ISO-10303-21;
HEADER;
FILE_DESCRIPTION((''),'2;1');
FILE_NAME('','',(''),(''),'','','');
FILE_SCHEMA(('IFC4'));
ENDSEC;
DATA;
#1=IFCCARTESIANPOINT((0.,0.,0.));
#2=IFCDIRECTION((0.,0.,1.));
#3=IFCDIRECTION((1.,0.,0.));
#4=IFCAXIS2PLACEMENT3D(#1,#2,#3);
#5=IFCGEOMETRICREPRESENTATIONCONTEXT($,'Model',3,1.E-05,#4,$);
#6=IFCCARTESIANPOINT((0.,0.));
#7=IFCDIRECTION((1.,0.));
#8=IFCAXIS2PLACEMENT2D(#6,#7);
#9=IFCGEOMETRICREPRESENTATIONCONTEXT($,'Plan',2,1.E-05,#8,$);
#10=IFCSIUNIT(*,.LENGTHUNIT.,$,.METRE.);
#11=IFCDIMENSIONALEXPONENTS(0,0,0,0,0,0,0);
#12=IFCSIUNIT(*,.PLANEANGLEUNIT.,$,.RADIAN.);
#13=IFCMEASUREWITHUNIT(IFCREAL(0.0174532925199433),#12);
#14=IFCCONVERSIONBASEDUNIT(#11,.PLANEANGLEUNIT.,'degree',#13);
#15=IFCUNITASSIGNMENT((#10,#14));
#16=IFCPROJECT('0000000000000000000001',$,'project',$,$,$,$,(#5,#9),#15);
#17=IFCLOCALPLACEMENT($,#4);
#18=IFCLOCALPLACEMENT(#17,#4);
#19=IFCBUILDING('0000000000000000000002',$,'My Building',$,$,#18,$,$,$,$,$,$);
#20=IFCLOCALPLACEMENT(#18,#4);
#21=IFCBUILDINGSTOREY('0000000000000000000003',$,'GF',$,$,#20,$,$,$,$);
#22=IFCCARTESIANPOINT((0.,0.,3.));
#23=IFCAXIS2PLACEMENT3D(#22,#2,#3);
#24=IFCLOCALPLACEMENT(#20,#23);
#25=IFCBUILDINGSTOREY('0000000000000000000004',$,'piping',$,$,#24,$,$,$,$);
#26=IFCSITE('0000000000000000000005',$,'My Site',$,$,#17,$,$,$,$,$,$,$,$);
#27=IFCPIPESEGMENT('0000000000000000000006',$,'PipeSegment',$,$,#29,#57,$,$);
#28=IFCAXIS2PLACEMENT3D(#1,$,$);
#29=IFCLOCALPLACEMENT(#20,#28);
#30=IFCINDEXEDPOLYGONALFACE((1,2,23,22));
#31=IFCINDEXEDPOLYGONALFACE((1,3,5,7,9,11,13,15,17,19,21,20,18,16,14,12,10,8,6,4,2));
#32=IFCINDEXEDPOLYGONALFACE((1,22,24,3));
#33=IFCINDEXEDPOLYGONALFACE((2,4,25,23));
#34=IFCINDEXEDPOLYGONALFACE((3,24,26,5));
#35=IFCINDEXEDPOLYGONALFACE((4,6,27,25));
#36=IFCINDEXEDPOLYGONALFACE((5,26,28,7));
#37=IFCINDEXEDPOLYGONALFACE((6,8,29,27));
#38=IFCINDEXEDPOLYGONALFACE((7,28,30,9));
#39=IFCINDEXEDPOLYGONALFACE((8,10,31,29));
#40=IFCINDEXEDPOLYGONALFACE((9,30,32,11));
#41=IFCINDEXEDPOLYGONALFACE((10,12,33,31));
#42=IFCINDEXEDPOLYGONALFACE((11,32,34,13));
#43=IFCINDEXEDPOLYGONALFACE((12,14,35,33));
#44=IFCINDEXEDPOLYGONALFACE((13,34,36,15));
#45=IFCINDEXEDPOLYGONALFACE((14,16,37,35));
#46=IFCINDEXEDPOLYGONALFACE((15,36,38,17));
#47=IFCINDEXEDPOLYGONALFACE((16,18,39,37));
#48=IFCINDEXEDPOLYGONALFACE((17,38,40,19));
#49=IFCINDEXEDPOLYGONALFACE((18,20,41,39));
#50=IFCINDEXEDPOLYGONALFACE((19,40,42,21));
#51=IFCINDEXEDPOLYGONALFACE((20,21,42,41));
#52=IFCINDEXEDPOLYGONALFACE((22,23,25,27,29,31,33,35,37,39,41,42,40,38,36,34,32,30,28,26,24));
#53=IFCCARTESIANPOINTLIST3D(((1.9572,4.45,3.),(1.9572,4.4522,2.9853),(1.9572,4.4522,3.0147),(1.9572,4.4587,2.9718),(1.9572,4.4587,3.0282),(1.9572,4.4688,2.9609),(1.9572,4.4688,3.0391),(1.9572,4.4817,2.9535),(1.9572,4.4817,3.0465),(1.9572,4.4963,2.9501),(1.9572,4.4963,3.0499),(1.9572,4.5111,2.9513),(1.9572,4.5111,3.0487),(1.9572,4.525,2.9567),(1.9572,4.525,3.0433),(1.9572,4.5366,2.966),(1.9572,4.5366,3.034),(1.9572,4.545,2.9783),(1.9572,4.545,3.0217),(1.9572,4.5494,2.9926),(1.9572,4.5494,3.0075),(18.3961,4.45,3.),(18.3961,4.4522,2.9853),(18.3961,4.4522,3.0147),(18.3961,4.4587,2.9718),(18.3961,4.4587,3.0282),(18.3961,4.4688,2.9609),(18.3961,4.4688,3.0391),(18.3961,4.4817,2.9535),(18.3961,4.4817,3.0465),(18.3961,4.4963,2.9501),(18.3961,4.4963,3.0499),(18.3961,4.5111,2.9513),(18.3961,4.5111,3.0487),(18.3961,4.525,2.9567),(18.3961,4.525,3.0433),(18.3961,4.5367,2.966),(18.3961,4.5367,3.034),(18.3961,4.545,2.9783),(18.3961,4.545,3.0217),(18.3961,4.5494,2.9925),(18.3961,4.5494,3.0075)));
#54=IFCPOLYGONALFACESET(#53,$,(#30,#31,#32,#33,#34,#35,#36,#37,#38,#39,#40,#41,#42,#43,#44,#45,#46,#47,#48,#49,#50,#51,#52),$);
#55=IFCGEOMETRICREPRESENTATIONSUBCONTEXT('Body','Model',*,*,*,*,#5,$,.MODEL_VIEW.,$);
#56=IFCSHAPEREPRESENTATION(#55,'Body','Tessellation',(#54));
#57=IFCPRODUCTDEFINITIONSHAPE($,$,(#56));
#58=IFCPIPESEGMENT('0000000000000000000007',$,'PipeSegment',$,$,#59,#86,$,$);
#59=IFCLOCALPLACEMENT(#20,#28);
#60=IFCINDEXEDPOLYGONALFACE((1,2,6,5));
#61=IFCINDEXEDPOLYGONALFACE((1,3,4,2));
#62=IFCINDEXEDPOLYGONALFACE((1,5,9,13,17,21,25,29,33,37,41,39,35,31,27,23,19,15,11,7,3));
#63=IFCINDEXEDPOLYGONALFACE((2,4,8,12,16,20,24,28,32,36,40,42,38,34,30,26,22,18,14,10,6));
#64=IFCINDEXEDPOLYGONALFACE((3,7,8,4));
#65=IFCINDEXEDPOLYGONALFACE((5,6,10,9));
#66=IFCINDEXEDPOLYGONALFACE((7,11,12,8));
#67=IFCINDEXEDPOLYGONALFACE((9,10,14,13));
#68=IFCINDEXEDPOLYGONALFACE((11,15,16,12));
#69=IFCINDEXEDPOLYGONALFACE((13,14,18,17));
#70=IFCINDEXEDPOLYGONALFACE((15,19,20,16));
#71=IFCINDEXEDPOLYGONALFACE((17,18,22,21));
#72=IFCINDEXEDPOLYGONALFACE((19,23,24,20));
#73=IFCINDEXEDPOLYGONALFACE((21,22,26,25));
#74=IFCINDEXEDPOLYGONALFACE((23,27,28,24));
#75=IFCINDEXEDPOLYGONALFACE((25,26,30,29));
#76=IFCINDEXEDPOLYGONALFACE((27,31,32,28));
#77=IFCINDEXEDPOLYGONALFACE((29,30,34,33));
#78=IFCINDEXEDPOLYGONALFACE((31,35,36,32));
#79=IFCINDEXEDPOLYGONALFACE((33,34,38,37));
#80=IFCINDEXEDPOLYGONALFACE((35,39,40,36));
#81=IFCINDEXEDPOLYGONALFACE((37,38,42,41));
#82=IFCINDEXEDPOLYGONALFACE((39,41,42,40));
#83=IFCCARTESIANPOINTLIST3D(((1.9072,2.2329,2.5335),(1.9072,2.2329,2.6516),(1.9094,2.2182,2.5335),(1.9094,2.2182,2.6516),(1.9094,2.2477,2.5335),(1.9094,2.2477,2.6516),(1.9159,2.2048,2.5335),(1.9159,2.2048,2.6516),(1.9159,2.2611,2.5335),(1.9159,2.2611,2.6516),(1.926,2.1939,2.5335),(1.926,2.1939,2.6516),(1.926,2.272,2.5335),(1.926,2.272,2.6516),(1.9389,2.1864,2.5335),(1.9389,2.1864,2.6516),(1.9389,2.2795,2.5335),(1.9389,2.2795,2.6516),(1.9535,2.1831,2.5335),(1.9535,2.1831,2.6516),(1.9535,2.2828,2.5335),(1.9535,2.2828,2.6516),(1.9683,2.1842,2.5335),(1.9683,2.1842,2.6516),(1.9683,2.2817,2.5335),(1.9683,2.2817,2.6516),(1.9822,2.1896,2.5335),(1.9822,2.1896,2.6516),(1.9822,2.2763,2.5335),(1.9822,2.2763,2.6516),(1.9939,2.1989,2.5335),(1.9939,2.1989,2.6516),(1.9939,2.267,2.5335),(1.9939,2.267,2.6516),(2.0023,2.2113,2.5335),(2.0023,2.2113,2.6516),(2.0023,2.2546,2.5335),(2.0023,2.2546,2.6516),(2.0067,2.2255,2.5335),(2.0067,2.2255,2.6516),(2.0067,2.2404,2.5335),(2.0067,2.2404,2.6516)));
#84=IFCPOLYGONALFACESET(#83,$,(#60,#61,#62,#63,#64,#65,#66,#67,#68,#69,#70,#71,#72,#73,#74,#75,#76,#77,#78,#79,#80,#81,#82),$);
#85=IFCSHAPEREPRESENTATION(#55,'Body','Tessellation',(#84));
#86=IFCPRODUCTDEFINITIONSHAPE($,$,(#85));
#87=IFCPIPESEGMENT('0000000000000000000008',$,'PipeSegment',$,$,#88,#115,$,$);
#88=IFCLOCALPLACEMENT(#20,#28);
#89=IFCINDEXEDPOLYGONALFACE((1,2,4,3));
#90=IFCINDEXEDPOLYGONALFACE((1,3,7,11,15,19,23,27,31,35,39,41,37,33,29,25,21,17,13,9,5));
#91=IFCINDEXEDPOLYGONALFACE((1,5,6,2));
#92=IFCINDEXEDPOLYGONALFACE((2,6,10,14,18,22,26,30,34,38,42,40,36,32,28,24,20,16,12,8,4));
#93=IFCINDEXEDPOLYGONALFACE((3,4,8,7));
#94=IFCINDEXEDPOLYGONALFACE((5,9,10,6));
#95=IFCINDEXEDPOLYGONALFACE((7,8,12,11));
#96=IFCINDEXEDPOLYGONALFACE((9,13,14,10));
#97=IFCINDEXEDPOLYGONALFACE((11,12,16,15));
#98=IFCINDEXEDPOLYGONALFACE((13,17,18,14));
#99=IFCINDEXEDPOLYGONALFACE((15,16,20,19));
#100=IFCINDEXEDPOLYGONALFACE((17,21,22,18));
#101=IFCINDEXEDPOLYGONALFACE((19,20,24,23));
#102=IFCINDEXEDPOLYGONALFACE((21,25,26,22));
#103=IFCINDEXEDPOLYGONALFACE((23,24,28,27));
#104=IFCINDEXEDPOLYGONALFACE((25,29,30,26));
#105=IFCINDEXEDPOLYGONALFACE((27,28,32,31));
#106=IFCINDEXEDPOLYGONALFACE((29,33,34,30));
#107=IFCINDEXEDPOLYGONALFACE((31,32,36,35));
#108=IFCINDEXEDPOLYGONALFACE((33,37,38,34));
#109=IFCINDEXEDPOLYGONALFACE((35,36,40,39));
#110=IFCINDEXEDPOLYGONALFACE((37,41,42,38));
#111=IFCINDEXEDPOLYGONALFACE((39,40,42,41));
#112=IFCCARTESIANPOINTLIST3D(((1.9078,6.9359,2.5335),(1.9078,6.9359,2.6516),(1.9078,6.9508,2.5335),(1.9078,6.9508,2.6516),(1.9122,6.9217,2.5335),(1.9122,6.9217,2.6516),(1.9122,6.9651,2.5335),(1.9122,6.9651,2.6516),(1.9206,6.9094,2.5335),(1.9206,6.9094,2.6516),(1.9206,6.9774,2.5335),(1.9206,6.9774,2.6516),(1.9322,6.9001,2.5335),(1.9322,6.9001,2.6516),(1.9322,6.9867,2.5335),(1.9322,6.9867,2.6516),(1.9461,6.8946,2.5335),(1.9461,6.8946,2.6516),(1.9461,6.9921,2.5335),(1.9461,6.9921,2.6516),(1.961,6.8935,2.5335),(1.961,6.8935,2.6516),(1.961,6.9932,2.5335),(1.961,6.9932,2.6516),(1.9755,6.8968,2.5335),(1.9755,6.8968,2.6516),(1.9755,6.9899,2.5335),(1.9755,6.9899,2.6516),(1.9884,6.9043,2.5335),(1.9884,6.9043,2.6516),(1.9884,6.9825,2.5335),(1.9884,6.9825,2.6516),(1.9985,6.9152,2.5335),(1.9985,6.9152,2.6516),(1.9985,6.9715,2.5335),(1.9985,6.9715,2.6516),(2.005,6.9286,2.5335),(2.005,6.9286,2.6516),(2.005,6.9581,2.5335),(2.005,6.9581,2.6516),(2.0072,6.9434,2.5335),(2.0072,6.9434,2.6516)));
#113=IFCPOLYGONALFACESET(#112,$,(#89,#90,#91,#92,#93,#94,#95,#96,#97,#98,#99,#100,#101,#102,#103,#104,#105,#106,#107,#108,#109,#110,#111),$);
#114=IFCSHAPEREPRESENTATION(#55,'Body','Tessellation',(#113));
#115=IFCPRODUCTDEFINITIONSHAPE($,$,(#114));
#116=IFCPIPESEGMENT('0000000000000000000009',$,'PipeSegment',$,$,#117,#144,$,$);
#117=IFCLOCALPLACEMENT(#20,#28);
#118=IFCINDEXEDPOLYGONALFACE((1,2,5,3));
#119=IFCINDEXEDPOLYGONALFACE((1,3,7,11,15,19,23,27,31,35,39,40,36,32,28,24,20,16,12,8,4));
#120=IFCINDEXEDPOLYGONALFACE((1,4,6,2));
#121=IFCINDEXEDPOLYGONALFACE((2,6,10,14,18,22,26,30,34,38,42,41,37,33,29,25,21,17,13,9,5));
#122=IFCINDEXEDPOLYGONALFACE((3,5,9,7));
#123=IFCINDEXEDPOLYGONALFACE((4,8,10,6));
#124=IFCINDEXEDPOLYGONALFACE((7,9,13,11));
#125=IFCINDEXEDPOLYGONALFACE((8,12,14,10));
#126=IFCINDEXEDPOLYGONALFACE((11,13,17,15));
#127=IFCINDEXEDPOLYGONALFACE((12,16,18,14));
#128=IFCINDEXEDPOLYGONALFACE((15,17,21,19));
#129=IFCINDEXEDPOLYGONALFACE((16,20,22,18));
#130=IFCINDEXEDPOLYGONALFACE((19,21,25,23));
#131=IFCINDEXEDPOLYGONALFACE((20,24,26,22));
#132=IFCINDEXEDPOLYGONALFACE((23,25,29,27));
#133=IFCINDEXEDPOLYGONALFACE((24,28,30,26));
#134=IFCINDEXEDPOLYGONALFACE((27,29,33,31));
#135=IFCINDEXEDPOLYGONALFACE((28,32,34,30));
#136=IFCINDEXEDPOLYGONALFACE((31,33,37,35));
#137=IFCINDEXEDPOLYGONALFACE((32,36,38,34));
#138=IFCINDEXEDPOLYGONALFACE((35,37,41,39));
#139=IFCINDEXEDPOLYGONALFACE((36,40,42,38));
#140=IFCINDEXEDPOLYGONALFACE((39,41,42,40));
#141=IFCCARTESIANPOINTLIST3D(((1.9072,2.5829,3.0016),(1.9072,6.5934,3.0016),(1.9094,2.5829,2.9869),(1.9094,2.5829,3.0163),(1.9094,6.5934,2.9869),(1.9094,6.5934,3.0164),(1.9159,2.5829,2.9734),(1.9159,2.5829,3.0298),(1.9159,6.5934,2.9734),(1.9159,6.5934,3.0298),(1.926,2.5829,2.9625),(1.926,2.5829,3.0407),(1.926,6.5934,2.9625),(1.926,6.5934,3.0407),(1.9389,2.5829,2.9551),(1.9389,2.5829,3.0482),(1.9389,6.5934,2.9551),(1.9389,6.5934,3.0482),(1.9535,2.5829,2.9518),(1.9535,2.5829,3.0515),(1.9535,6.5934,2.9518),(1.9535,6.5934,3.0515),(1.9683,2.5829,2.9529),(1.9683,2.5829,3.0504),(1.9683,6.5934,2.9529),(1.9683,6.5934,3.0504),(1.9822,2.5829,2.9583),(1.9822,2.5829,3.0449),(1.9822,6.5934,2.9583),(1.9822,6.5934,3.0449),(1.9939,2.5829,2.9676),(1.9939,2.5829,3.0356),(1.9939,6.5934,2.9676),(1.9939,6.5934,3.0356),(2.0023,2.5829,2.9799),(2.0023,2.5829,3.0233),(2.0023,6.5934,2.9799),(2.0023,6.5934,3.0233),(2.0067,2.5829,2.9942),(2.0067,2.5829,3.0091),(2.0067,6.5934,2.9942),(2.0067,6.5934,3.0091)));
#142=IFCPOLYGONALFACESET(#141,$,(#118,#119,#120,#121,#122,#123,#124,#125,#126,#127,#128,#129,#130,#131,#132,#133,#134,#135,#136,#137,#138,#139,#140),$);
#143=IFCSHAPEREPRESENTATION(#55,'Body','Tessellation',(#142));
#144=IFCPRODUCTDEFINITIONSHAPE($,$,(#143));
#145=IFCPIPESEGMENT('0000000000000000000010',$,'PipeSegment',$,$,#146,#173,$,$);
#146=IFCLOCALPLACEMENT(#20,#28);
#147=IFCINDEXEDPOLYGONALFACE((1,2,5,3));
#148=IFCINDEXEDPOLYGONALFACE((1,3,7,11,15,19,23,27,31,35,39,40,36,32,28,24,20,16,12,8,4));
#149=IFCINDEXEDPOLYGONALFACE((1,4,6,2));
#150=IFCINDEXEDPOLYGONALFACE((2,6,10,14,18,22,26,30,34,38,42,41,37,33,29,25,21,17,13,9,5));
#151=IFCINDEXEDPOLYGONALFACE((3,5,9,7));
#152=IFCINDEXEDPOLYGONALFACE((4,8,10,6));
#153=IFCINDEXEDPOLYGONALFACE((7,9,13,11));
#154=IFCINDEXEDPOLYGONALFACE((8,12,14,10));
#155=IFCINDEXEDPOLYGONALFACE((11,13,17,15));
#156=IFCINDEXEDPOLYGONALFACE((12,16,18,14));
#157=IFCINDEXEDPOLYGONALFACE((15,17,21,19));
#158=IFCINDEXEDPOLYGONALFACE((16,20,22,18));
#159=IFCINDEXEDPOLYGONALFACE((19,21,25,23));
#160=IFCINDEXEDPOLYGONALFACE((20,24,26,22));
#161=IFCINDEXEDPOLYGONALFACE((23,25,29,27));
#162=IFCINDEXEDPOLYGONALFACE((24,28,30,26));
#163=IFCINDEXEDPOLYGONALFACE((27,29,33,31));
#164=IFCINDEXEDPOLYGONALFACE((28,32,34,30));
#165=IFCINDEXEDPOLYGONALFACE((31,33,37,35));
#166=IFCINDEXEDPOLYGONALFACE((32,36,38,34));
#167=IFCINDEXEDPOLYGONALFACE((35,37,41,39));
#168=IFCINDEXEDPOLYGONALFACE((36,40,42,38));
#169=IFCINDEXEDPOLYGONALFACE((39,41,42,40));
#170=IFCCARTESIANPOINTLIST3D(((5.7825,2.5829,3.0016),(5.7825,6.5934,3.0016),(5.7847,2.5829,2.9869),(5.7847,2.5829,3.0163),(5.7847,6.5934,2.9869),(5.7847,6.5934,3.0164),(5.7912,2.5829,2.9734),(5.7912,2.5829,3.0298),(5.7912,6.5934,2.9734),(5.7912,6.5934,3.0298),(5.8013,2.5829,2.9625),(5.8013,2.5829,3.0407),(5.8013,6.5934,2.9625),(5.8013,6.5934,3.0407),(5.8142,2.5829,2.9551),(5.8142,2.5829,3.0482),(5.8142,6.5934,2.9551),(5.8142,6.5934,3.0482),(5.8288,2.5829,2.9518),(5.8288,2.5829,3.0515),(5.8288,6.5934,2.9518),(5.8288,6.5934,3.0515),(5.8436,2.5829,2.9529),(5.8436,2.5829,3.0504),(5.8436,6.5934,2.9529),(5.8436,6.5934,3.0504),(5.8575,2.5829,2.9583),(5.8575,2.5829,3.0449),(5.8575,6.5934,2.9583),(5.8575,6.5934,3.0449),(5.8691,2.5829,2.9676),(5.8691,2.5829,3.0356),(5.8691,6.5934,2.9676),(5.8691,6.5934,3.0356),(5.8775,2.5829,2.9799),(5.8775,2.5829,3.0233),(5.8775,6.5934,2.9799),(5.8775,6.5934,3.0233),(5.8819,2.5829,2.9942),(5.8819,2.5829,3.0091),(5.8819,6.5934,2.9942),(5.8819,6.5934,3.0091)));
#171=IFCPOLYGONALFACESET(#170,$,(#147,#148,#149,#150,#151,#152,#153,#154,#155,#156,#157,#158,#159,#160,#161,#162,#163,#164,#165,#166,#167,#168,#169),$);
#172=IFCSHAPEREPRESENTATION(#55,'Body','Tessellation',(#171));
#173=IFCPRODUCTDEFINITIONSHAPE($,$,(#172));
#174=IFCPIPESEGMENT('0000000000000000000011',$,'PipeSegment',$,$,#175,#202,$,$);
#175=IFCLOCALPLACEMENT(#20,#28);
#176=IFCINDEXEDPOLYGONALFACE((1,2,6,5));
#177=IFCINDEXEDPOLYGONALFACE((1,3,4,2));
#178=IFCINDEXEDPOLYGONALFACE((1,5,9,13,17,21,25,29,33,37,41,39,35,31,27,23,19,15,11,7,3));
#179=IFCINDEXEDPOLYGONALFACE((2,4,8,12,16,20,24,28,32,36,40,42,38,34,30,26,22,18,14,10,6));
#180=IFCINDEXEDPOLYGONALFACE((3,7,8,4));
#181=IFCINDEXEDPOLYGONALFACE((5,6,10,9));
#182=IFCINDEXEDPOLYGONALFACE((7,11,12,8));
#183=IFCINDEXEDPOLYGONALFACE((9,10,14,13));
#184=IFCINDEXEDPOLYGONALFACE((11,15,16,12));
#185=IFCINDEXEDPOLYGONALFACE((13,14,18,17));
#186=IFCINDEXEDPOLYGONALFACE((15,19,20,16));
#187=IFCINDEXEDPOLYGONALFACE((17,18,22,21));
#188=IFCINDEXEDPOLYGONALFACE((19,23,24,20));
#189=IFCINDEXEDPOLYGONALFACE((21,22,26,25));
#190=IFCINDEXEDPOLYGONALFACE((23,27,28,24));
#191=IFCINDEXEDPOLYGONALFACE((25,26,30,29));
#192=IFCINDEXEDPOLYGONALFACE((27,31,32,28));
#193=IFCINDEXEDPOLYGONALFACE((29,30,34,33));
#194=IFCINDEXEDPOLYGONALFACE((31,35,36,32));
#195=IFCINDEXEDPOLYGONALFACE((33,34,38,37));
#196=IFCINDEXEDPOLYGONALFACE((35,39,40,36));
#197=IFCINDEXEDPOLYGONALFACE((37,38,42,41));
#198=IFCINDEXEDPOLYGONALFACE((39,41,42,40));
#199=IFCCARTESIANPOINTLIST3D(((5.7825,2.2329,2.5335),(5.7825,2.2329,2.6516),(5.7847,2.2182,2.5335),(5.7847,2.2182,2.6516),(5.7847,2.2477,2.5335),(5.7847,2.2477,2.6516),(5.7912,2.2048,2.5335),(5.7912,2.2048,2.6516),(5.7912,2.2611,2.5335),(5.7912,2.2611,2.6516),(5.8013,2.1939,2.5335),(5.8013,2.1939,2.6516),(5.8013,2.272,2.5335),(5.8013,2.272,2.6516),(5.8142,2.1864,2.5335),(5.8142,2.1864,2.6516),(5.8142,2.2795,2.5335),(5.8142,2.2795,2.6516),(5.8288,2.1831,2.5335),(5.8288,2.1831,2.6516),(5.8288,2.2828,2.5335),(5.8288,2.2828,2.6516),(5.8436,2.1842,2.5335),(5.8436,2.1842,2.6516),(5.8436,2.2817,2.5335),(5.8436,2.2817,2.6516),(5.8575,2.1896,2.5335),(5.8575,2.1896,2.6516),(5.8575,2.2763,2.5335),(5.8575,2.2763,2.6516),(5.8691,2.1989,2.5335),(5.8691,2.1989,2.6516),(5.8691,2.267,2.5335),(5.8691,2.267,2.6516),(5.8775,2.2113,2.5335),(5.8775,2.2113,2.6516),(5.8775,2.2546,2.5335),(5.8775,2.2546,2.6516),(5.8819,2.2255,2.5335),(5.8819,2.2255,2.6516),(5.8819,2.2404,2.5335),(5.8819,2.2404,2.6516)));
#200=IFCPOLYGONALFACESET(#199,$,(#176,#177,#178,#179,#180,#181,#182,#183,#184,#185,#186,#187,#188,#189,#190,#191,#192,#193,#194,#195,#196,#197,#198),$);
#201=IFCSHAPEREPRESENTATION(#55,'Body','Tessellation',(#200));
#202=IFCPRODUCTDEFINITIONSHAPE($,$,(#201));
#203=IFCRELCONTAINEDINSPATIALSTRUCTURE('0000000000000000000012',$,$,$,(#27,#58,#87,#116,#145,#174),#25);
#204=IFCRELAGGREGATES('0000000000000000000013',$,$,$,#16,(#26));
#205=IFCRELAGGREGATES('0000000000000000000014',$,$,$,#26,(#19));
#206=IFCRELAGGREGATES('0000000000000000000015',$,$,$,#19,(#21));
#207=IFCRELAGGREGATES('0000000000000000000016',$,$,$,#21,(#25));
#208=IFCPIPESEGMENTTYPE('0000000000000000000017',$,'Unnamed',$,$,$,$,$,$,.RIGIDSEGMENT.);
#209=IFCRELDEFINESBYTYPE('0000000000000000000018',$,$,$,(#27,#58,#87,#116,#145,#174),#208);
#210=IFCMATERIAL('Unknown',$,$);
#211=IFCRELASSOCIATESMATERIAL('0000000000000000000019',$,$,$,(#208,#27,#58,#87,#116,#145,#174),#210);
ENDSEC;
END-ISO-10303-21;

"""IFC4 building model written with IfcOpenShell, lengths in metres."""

from ifc_helpers import new_model, entity, si_unit, converted_unit, frame, origin_with_axes, origin_2d_with_axis, place, context, subcontext, project, spatial, circle, extrude, material, material_profile, profile_set, profile_usage, type_object, element, save


model = new_model("IFC4")

# Units and contexts
model_context = context("Model", 3, precision=1e-05, world=origin_with_axes())
plan_context = context("Plan", 2, precision=1e-05, world=origin_2d_with_axis())
body_context = subcontext(model_context, "Body", "Model", "MODEL_VIEW")
ifc_project = project(units=[si_unit("LENGTHUNIT", "METRE"), converted_unit("PLANEANGLEUNIT", "degree", entity("IfcReal", 0.0174532925199433), si_unit("PLANEANGLEUNIT", "RADIAN"), dimensions=[0, 0, 0, 0, 0, 0, 0])], contexts=[model_context, plan_context])

# Site, building, storeys
site_placement = place(None, origin_with_axes())
site = spatial("IfcSite", under=ifc_project, at=site_placement, Name="My Site")
building_placement = place(site_placement, origin_with_axes())
building = spatial("IfcBuilding", under=site, at=building_placement, Name="My Building")
storey_1_placement = place(building_placement, origin_with_axes())
storey_1 = spatial("IfcBuildingStorey", under=building, at=storey_1_placement, Name="GF")
storey_2_placement = place(storey_1_placement, frame((0.0, 0.0, 3.0), z_axis=(0.0, 0.0, 1.0), x_axis=(1.0, 0.0, 0.0)))
storey_2 = spatial("IfcBuildingStorey", under=storey_1, at=storey_2_placement, Name="piping")

# Pipe segments
ifc_material = material(Name="Unknown")
ifc_material_profile = material_profile(ifc_material, circle(Radius=0.05))
ifc_profile_set = profile_set([ifc_material_profile])
ifc_profile_usage_1 = profile_usage(ifc_profile_set, cardinal=5)
pipe_segment_type = type_object("IfcPipeSegmentType", Name="Unnamed", PredefinedType="RIGIDSEGMENT", material=ifc_profile_set)
pipe_segment_1_placement = place(storey_2_placement, frame((18.3961, 4.5, 0.0), z_axis=(-1.0, 0.0, 0.0), x_axis=(0.0, -1.0, 0.0)))
element("IfcPipeSegment", 1, at=pipe_segment_1_placement, inside=storey_2, type_object=pipe_segment_type, material=ifc_profile_usage_1, Name="PipeSegment", context=body_context, shape_type="SweptSolid", body=[
    extrude(circle(Radius=0.05), origin_with_axes(), (0.0, 0.0, 1.0), 16.4389),
])
ifc_profile_usage_2 = profile_usage(ifc_profile_set, cardinal=5)
pipe_segment_2_placement = place(storey_2_placement, frame((1.9572, 2.2329, -0.3484), z_axis=(0.0, 0.0, -1.0), x_axis=(-1.0, 0.0, 0.0)))
element("IfcPipeSegment", 2, at=pipe_segment_2_placement, inside=storey_2, type_object=pipe_segment_type, material=ifc_profile_usage_2, Name="PipeSegment", context=body_context, shape_type="SweptSolid", body=[
    extrude(circle(Radius=0.05), origin_with_axes(), (0.0, 0.0, 1.0), 0.1181),
])
ifc_profile_usage_3 = profile_usage(ifc_profile_set, cardinal=5)
pipe_segment_3_placement = place(storey_2_placement, frame((1.9572, 6.9434, -0.3484), z_axis=(0.0, 0.0, -1.0), x_axis=(1.0, 0.0, 0.0)))
element("IfcPipeSegment", 3, at=pipe_segment_3_placement, inside=storey_2, type_object=pipe_segment_type, material=ifc_profile_usage_3, Name="PipeSegment", context=body_context, shape_type="SweptSolid", body=[
    extrude(circle(Radius=0.05), origin_with_axes(), (0.0, 0.0, 1.0), 0.1181),
])
ifc_profile_usage_4 = profile_usage(ifc_profile_set, cardinal=5)
pipe_segment_4_placement = place(storey_2_placement, frame((1.9572, 2.5829, 0.0016), z_axis=(0.0, 1.0, 0.0), x_axis=(-1.0, 0.0, 0.0)))
element("IfcPipeSegment", 4, at=pipe_segment_4_placement, inside=storey_2, type_object=pipe_segment_type, material=ifc_profile_usage_4, Name="PipeSegment", context=body_context, shape_type="SweptSolid", body=[
    extrude(circle(Radius=0.05), origin_with_axes(), (0.0, 0.0, 1.0), 4.0104),
])
ifc_profile_usage_5 = profile_usage(ifc_profile_set, cardinal=5)
pipe_segment_5_placement = place(storey_2_placement, frame((5.8325, 2.5829, 0.0016), z_axis=(0.0, 1.0, 0.0), x_axis=(-1.0, 0.0, 0.0)))
element("IfcPipeSegment", 5, at=pipe_segment_5_placement, inside=storey_2, type_object=pipe_segment_type, material=ifc_profile_usage_5, Name="PipeSegment", context=body_context, shape_type="SweptSolid", body=[
    extrude(circle(Radius=0.05), origin_with_axes(), (0.0, 0.0, 1.0), 4.0104),
])
ifc_profile_usage_6 = profile_usage(ifc_profile_set, cardinal=5)
pipe_segment_6_placement = place(storey_2_placement, frame((5.8325, 2.2329, -0.3484), z_axis=(0.0, 0.0, -1.0), x_axis=(-1.0, 0.0, 0.0)))
element("IfcPipeSegment", 6, at=pipe_segment_6_placement, inside=storey_2, type_object=pipe_segment_type, material=ifc_profile_usage_6, Name="PipeSegment", context=body_context, shape_type="SweptSolid", body=[
    extrude(circle(Radius=0.05), origin_with_axes(), (0.0, 0.0, 1.0), 0.1181),
])

save(model, "model.ifc")
